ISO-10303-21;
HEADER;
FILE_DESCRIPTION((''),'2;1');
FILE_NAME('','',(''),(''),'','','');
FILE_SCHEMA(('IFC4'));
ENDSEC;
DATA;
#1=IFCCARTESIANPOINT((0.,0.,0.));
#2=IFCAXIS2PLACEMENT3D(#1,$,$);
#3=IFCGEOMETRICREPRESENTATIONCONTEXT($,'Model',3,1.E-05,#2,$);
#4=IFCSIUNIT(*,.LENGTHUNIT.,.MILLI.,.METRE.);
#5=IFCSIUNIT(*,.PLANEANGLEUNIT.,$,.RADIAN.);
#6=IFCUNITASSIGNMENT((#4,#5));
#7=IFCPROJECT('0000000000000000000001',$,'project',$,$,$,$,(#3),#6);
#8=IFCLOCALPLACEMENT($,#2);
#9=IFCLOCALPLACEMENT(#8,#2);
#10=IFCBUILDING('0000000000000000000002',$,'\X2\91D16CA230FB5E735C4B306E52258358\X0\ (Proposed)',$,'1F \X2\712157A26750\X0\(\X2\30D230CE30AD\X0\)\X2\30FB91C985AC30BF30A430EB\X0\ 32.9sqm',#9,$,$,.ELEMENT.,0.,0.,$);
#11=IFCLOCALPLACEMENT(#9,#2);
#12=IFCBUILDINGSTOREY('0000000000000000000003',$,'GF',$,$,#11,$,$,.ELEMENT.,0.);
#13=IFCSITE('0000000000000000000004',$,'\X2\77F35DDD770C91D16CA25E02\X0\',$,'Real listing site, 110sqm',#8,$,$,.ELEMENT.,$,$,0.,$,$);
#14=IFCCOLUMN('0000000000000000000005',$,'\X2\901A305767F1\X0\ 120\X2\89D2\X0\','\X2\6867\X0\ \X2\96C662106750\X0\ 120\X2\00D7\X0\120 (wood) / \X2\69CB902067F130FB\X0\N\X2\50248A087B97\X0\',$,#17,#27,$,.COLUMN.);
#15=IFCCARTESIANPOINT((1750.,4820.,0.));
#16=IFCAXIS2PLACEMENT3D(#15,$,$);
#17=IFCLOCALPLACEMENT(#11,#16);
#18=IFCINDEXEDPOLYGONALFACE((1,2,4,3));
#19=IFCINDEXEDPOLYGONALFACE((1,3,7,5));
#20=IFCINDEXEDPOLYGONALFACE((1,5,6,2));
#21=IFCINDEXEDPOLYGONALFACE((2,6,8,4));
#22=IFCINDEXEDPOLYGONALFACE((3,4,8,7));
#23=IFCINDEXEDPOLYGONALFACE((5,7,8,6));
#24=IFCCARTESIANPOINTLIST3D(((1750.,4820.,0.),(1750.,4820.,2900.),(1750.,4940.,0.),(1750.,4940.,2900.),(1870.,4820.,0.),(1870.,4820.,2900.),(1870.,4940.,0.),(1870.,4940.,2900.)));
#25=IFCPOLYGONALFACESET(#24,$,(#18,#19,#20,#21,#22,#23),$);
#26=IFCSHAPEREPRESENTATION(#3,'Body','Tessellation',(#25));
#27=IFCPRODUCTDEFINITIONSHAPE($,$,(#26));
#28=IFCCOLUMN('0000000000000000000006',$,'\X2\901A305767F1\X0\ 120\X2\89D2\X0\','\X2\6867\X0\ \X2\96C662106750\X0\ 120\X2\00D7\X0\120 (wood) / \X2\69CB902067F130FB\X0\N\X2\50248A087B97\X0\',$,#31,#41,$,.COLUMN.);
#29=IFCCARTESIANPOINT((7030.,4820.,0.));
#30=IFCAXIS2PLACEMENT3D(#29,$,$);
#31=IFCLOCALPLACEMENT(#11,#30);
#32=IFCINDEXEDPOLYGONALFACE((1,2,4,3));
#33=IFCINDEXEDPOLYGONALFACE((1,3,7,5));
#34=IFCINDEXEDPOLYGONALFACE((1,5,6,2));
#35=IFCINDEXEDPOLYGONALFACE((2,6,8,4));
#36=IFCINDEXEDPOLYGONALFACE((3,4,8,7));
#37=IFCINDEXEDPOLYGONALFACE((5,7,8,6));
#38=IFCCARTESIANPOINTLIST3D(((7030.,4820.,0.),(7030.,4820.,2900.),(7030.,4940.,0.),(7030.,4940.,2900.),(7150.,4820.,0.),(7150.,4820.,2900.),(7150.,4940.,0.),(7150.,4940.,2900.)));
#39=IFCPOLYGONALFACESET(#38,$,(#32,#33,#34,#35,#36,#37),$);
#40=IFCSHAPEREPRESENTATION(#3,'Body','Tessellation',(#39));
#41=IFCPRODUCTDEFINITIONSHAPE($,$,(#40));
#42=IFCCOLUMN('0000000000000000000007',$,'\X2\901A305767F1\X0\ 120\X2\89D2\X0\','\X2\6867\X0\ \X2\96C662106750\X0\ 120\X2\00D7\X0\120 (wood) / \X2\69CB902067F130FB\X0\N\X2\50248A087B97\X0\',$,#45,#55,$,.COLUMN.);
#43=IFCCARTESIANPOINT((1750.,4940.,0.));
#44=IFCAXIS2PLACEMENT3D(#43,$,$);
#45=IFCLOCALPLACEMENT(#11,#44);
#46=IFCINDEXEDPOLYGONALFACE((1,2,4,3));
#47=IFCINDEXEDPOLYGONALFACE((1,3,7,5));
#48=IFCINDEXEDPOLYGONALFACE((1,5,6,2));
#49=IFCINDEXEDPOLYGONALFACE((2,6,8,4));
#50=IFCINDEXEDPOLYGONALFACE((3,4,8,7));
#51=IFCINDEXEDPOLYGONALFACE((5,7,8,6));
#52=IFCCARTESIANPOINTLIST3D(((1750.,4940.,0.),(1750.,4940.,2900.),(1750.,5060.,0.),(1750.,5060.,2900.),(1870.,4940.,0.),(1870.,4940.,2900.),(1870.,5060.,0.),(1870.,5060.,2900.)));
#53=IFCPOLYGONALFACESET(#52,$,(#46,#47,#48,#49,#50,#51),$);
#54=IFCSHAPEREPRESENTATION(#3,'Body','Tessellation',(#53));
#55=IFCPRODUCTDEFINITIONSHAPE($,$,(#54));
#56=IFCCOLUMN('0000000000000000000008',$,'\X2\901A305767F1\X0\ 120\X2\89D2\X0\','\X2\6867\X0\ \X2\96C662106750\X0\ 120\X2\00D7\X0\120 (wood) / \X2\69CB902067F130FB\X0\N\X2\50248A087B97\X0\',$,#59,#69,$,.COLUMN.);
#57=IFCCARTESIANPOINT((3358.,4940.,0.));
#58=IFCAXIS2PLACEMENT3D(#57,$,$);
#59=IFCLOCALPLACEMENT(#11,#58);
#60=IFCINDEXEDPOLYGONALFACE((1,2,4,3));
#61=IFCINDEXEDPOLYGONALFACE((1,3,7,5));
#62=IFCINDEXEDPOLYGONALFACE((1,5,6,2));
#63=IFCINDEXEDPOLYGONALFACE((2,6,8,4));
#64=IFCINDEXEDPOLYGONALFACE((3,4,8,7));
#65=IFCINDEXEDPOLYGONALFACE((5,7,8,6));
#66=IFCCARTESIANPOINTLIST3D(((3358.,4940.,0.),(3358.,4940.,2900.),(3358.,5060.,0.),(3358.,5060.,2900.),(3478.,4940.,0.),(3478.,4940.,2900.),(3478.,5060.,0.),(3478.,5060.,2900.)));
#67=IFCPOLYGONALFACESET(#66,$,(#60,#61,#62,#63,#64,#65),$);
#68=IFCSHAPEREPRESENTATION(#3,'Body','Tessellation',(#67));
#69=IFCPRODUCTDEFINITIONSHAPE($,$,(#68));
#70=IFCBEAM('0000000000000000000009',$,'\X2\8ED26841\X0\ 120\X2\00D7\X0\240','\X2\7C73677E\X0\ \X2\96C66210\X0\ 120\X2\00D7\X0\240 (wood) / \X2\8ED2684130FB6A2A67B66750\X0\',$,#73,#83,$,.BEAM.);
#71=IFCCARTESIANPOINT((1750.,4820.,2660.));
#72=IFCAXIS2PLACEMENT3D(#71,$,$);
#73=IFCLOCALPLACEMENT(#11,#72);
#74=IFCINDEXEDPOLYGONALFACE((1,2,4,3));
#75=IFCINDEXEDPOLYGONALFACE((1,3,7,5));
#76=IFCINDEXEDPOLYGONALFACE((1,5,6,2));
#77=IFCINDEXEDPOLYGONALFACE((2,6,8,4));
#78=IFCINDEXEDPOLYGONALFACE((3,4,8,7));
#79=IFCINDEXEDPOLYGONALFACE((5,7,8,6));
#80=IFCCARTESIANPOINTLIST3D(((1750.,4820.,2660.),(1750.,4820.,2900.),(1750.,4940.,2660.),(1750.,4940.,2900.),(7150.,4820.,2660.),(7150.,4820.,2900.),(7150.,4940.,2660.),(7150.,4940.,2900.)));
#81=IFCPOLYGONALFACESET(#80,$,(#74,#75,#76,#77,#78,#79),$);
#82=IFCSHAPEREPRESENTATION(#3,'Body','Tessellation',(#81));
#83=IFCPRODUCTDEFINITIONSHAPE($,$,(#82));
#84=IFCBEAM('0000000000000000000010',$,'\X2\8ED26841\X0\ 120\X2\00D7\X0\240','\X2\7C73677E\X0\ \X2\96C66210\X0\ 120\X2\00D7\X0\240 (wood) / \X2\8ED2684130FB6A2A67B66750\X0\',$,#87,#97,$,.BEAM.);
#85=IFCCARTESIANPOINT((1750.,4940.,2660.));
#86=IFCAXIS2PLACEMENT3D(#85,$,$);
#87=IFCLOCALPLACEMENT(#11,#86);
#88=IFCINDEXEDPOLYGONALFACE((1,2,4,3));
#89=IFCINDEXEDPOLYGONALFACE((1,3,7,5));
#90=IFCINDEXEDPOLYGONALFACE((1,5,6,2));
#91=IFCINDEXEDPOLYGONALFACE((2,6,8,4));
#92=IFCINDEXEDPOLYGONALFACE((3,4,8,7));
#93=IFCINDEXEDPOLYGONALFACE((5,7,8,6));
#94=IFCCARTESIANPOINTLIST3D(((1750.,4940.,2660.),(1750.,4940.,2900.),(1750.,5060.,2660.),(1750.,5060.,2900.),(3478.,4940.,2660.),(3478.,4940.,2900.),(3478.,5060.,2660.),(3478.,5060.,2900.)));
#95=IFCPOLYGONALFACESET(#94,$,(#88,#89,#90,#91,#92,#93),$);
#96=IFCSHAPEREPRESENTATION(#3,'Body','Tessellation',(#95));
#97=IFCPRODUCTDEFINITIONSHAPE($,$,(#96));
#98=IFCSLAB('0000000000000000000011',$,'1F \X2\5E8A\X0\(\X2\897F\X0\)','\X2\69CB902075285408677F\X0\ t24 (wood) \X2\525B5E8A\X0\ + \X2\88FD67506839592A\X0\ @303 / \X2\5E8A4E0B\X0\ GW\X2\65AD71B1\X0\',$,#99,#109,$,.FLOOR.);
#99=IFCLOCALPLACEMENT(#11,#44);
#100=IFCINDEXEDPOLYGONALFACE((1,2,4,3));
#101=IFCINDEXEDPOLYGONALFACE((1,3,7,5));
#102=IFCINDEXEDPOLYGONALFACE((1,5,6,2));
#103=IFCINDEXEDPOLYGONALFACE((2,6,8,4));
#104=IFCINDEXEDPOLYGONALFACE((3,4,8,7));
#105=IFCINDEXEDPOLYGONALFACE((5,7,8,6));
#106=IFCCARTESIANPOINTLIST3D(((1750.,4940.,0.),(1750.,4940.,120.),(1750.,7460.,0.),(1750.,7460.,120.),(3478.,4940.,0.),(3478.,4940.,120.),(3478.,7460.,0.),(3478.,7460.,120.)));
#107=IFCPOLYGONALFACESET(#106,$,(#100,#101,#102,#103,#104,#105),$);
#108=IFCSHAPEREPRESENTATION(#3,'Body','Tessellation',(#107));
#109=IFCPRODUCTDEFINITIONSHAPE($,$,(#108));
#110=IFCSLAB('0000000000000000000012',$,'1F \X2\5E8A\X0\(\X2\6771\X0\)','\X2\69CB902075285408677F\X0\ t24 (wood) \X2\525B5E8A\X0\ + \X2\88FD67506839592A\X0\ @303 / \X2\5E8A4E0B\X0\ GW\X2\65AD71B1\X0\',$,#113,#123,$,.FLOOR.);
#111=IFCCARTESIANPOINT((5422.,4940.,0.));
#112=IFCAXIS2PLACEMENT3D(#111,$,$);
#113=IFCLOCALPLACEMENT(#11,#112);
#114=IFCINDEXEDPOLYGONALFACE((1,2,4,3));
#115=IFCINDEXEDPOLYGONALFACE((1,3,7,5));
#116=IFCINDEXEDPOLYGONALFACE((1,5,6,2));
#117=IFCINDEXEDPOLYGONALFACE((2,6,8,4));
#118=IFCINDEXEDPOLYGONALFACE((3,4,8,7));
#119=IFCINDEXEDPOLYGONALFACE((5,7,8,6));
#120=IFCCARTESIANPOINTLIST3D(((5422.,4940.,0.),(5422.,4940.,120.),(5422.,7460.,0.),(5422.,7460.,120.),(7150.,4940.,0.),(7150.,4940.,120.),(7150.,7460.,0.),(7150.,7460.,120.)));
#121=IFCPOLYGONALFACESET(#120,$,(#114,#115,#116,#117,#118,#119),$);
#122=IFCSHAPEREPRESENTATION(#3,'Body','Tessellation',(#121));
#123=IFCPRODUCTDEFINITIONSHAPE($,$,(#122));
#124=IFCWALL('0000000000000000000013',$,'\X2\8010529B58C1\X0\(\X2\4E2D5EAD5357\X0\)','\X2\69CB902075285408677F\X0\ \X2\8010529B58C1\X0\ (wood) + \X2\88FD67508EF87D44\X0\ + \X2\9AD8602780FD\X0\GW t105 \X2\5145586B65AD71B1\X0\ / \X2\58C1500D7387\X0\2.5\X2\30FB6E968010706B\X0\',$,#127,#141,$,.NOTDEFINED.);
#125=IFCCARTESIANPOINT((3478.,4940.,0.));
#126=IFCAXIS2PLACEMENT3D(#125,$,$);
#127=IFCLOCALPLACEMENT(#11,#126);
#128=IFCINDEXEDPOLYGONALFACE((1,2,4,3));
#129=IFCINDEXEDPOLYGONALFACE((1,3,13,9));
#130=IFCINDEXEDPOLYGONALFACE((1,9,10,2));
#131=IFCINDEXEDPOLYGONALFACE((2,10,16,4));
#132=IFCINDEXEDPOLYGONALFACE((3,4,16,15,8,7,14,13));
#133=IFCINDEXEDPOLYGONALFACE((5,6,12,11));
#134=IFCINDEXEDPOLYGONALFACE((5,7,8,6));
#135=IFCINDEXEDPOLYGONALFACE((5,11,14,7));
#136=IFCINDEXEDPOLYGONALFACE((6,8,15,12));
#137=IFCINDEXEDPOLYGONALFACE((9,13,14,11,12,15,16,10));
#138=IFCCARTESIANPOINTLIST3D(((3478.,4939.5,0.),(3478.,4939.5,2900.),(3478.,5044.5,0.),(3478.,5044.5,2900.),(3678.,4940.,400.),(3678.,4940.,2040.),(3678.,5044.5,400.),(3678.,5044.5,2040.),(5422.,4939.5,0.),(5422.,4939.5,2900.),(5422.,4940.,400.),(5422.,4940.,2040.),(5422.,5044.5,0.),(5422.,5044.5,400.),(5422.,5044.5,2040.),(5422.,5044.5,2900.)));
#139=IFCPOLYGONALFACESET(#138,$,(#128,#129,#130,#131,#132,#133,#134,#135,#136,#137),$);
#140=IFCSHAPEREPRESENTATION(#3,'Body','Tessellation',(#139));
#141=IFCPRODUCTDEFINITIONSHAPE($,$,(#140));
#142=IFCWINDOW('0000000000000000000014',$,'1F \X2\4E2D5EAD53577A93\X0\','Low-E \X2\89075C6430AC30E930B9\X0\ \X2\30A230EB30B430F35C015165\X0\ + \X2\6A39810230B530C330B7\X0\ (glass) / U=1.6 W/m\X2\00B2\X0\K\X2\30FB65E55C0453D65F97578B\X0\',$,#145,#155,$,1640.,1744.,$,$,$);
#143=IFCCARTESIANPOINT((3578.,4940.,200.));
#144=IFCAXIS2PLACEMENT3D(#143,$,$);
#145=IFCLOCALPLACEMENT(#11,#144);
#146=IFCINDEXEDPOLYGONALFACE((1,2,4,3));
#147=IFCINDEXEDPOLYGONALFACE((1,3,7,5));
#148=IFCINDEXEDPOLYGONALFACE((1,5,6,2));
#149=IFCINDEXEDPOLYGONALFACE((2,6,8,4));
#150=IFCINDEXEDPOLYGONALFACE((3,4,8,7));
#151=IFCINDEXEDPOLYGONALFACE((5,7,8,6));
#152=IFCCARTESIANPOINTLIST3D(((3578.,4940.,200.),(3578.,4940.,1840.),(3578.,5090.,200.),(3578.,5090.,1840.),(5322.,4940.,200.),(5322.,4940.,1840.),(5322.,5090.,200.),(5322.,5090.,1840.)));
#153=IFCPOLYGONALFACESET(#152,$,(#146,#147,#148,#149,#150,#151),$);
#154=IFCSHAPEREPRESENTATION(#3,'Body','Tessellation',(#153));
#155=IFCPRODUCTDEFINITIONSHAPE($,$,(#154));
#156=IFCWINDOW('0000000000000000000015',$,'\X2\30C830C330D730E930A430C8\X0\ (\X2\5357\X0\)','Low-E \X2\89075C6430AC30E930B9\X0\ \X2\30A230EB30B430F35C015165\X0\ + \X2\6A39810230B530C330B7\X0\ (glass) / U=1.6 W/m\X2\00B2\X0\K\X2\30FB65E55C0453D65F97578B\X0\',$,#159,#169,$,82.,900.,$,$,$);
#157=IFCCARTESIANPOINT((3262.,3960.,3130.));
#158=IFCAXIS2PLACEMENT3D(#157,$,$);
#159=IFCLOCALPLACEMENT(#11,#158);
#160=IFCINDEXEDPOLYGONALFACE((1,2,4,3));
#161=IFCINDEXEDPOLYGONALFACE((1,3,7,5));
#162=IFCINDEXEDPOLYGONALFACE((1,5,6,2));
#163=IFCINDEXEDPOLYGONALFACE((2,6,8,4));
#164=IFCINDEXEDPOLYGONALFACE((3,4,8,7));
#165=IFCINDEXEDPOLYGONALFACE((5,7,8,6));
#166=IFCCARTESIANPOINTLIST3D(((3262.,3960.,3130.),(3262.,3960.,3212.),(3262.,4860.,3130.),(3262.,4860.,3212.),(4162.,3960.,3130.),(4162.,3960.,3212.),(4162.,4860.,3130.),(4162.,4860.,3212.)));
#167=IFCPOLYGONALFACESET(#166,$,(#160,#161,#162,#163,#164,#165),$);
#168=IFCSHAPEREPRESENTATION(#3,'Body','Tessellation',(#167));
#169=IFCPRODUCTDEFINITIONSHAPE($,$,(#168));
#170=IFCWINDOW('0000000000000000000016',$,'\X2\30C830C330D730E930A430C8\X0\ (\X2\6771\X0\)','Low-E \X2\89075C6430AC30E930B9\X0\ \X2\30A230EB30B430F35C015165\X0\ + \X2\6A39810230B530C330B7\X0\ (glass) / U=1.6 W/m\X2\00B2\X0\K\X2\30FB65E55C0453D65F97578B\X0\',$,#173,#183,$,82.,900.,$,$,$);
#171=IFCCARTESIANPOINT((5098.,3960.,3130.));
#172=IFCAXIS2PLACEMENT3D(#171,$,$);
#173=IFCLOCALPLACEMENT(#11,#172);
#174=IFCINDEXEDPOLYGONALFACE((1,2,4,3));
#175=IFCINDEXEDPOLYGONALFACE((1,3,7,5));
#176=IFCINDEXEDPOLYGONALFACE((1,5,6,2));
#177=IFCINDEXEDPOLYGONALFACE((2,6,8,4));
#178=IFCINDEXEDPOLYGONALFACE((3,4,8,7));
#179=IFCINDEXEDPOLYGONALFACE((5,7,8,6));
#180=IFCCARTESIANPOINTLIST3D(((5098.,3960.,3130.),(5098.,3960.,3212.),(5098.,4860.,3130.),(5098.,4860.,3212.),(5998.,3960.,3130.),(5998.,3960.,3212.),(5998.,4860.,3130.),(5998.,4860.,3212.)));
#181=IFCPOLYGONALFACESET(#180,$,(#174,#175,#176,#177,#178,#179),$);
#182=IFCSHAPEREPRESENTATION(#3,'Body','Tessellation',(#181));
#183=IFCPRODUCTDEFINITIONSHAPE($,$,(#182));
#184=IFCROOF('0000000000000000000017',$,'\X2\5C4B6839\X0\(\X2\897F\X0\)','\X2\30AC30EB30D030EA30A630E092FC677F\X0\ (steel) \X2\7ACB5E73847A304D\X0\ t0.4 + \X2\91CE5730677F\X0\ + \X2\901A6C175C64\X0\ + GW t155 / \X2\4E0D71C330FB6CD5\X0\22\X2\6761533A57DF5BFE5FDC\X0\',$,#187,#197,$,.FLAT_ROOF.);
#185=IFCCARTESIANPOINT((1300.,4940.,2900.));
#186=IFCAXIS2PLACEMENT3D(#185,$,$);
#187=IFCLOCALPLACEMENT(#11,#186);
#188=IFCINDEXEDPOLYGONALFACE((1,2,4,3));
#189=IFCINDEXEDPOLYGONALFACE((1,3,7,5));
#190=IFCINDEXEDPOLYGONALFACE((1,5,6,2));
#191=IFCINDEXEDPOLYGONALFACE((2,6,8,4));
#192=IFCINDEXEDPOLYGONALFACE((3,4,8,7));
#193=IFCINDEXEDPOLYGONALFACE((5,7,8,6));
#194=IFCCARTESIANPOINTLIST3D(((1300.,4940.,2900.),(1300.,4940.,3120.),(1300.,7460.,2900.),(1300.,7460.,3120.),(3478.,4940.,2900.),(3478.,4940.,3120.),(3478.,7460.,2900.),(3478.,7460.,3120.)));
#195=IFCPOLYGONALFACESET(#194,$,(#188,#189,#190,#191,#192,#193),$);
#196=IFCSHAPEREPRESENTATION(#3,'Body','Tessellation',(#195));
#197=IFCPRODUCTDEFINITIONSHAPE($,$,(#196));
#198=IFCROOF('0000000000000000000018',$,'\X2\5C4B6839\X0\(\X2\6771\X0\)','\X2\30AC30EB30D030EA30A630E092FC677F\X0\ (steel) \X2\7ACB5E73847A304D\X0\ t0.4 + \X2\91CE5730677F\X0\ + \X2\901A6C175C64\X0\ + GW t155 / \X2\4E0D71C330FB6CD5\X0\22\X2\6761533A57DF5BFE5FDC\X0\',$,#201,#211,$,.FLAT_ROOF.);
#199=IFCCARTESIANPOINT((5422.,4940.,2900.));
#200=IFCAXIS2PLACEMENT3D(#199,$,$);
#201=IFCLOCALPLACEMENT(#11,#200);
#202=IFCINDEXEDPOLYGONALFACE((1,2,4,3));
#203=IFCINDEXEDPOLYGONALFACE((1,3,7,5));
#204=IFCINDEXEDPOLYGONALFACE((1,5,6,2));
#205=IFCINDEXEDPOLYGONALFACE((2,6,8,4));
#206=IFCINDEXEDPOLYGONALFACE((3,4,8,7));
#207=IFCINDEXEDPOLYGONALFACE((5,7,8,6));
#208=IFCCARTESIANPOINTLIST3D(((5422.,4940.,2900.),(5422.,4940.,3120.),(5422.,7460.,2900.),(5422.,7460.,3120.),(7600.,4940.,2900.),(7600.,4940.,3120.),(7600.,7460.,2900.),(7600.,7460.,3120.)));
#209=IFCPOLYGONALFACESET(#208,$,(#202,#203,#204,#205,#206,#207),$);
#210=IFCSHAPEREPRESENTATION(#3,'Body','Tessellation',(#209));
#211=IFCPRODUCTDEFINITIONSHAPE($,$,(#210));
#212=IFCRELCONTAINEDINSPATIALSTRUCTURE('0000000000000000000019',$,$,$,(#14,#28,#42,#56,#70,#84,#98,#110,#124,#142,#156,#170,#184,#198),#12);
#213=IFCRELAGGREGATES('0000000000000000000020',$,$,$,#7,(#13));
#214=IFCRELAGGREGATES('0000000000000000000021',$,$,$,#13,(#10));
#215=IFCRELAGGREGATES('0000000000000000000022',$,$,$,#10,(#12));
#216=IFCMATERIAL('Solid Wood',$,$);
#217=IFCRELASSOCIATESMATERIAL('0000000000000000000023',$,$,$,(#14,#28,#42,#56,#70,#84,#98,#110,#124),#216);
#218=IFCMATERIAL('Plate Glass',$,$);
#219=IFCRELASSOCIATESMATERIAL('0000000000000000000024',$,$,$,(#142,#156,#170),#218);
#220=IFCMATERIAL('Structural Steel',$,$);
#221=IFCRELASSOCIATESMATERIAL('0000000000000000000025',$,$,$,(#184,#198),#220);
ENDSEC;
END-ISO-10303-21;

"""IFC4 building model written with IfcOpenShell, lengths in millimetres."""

from ifc_helpers import new_model, si_unit, frame, frame_2d, origin, place, context, project, spatial, rectangle, extrude, material, element, fill, save


model = new_model("IFC4")

# Units and contexts
model_context = context("Model", 3, precision=1e-05, world=origin())
ifc_project = project(units=[si_unit("LENGTHUNIT", "METRE", prefix="MILLI"), si_unit("PLANEANGLEUNIT", "RADIAN")], contexts=[model_context])

# Site, building, storey
site_placement = place(None, origin())
site = spatial("IfcSite", under=ifc_project, at=site_placement, Name="石川県金沢市", ObjectType="Real listing site, 110sqm", CompositionType="ELEMENT", RefElevation=0.0)
building_placement = place(site_placement, origin())
building = spatial("IfcBuilding", under=site, at=building_placement, Name="金沢・平屋の別荘 (Proposed)", ObjectType="1F 無垢材(ヒノキ)・釉薬タイル 32.9sqm", CompositionType="ELEMENT", ElevationOfRefHeight=0.0, ElevationOfTerrain=0.0)
storey_placement = place(building_placement, origin())
storey = spatial("IfcBuildingStorey", under=building, at=storey_placement, Name="GF", CompositionType="ELEMENT", Elevation=0.0)

# Columns
ifc_material_1 = material(Name="Solid Wood")
column_1_placement = place(storey_placement, frame((1750.0, 4820.0, 0.0)))
element("IfcColumn", 1, at=column_1_placement, inside=storey, material=ifc_material_1, Name="通し柱 120角", Description="桧 集成材 120×120 (wood) / 構造柱・N値計算", PredefinedType="COLUMN", context=model_context, shape_type="SweptSolid", body=[
    extrude(rectangle(XDim=120.0, YDim=120.0, at=frame_2d((60.0, 60.0))), frame((1750.0, 4820.0, 0.0)), (0.0, 0.0, 1.0), 2900.0),
])
column_2_placement = place(storey_placement, frame((7030.0, 4820.0, 0.0)))
element("IfcColumn", 2, at=column_2_placement, inside=storey, material=ifc_material_1, Name="通し柱 120角", Description="桧 集成材 120×120 (wood) / 構造柱・N値計算", PredefinedType="COLUMN", context=model_context, shape_type="SweptSolid", body=[
    extrude(rectangle(XDim=120.0, YDim=120.0, at=frame_2d((60.0, 60.0))), frame((7030.0, 4820.0, 0.0)), (0.0, 0.0, 1.0), 2900.0),
])
column_3_placement = place(storey_placement, frame((1750.0, 4940.0, 0.0)))
element("IfcColumn", 3, at=column_3_placement, inside=storey, material=ifc_material_1, Name="通し柱 120角", Description="桧 集成材 120×120 (wood) / 構造柱・N値計算", PredefinedType="COLUMN", context=model_context, shape_type="SweptSolid", body=[
    extrude(rectangle(XDim=120.0, YDim=120.0, at=frame_2d((60.0, 60.0))), frame((1750.0, 4940.0, 0.0)), (0.0, 0.0, 1.0), 2900.0),
])
column_4_placement = place(storey_placement, frame((3358.0, 4940.0, 0.0)))
element("IfcColumn", 4, at=column_4_placement, inside=storey, material=ifc_material_1, Name="通し柱 120角", Description="桧 集成材 120×120 (wood) / 構造柱・N値計算", PredefinedType="COLUMN", context=model_context, shape_type="SweptSolid", body=[
    extrude(rectangle(XDim=120.0, YDim=120.0, at=frame_2d((60.0, 60.0))), frame((3358.0, 4940.0, 0.0)), (0.0, 0.0, 1.0), 2900.0),
])

# Beams
beam_1_placement = place(storey_placement, frame((1750.0, 4820.0, 2660.0)))
element("IfcBeam", 5, at=beam_1_placement, inside=storey, material=ifc_material_1, Name="軒桁 120×240", Description="米松 集成 120×240 (wood) / 軒桁・横架材", PredefinedType="BEAM", context=model_context, shape_type="SweptSolid", body=[
    extrude(rectangle(XDim=5400.0, YDim=120.0, at=frame_2d((2700.0, 60.0))), frame((1750.0, 4820.0, 2660.0)), (0.0, 0.0, 1.0), 240.0),
])
beam_2_placement = place(storey_placement, frame((1750.0, 4940.0, 2660.0)))
element("IfcBeam", 6, at=beam_2_placement, inside=storey, material=ifc_material_1, Name="軒桁 120×240", Description="米松 集成 120×240 (wood) / 軒桁・横架材", PredefinedType="BEAM", context=model_context, shape_type="SweptSolid", body=[
    extrude(rectangle(XDim=1728.0, YDim=120.0, at=frame_2d((864.0, 60.0))), frame((1750.0, 4940.0, 2660.0)), (0.0, 0.0, 1.0), 240.0),
])

# Slabs
slab_1_placement = place(storey_placement, frame((1750.0, 4940.0, 0.0)))
element("IfcSlab", 7, at=slab_1_placement, inside=storey, material=ifc_material_1, Name="1F 床(西)", Description="構造用合板 t24 (wood) 剛床 + 製材根太 @303 / 床下 GW断熱", PredefinedType="FLOOR", context=model_context, shape_type="SweptSolid", body=[
    extrude(rectangle(XDim=1728.0, YDim=2520.0, at=frame_2d((864.0, 1260.0))), frame((1750.0, 4940.0, 0.0)), (0.0, 0.0, 1.0), 120.0),
])
slab_2_placement = place(storey_placement, frame((5422.0, 4940.0, 0.0)))
element("IfcSlab", 8, at=slab_2_placement, inside=storey, material=ifc_material_1, Name="1F 床(東)", Description="構造用合板 t24 (wood) 剛床 + 製材根太 @303 / 床下 GW断熱", PredefinedType="FLOOR", context=model_context, shape_type="SweptSolid", body=[
    extrude(rectangle(XDim=1728.0, YDim=2520.0, at=frame_2d((864.0, 1260.0))), frame((5422.0, 4940.0, 0.0)), (0.0, 0.0, 1.0), 120.0),
])

# Wall, opening, window
wall_1_placement = place(storey_placement, frame((3478.0, 4940.0, 0.0)))
wall_1 = element("IfcWall", 9, at=wall_1_placement, inside=storey, material=ifc_material_1, Name="耐力壁(中庭南)", Description="構造用合板 耐力壁 (wood) + 製材軸組 + 高性能GW t105 充填断熱 / 壁倍率2.5・準耐火", PredefinedType="NOTDEFINED", context=model_context, shape_type="SweptSolid", body=[
    extrude(rectangle(XDim=1944.0, YDim=105.0, at=frame_2d((972.0, 52.0))), frame((3478.0, 4940.0, 0.0)), (0.0, 0.0, 1.0), 2900.0),
])
opening_placement = place(storey_placement, frame((3578.0, 4940.0, 200.0)))
opening = element("IfcOpeningElement", 10, at=opening_placement, cuts=wall_1, PredefinedType="NOTDEFINED", context=model_context, shape_type="SweptSolid", body=[
    extrude(rectangle(XDim=1744.0, YDim=150.0, at=frame_2d((872.0, 75.0))), frame((3578.0, 4940.0, 200.0)), (0.0, 0.0, 1.0), 1640.0),
])
ifc_material_2 = material(Name="Plate Glass")
window_1_placement = place(storey_placement, frame((3578.0, 4940.0, 200.0)))
window_1 = element("IfcWindow", 11, at=window_1_placement, inside=storey, material=ifc_material_2, Name="1F 中庭南窓", Description="Low-E 複層ガラス アルゴン封入 + 樹脂サッシ (glass) / U=1.6 W/m²K・日射取得型", OverallHeight=1640.0, OverallWidth=1744.0, context=model_context, shape_type="SweptSolid", body=[
    extrude(rectangle(XDim=1744.0, YDim=150.0, at=frame_2d((872.0, 75.0))), frame((3578.0, 4940.0, 200.0)), (0.0, 0.0, 1.0), 1640.0),
])
fill(opening, window_1)

# Windows
window_2_placement = place(storey_placement, frame((3262.0, 3960.0, 3130.0)))
element("IfcWindow", 12, at=window_2_placement, inside=storey, material=ifc_material_2, Name="トップライト (南)", Description="Low-E 複層ガラス アルゴン封入 + 樹脂サッシ (glass) / U=1.6 W/m²K・日射取得型", OverallHeight=82.0, OverallWidth=900.0, context=model_context, shape_type="SweptSolid", body=[
    extrude(rectangle(XDim=900.0, YDim=900.0, at=frame_2d((450.0, 450.0))), frame((3262.0, 3960.0, 3130.0)), (0.0, 0.0, 1.0), 82.0),
])
window_3_placement = place(storey_placement, frame((5098.0, 3960.0, 3130.0)))
element("IfcWindow", 13, at=window_3_placement, inside=storey, material=ifc_material_2, Name="トップライト (東)", Description="Low-E 複層ガラス アルゴン封入 + 樹脂サッシ (glass) / U=1.6 W/m²K・日射取得型", OverallHeight=82.0, OverallWidth=900.0, context=model_context, shape_type="SweptSolid", body=[
    extrude(rectangle(XDim=900.0, YDim=900.0, at=frame_2d((450.0, 450.0))), frame((5098.0, 3960.0, 3130.0)), (0.0, 0.0, 1.0), 82.0),
])

# Roofs
ifc_material_3 = material(Name="Structural Steel")
roof_1_placement = place(storey_placement, frame((1300.0, 4940.0, 2900.0)))
element("IfcRoof", 14, at=roof_1_placement, inside=storey, material=ifc_material_3, Name="屋根(西)", Description="ガルバリウム鋼板 (steel) 立平葺き t0.4 + 野地板 + 通気層 + GW t155 / 不燃・法22条区域対応", PredefinedType="FLAT_ROOF", context=model_context, shape_type="SweptSolid", body=[
    extrude(rectangle(XDim=2178.0, YDim=2520.0, at=frame_2d((1089.0, 1260.0))), frame((1300.0, 4940.0, 2900.0)), (0.0, 0.0, 1.0), 220.0),
])
roof_2_placement = place(storey_placement, frame((5422.0, 4940.0, 2900.0)))
element("IfcRoof", 15, at=roof_2_placement, inside=storey, material=ifc_material_3, Name="屋根(東)", Description="ガルバリウム鋼板 (steel) 立平葺き t0.4 + 野地板 + 通気層 + GW t155 / 不燃・法22条区域対応", PredefinedType="FLAT_ROOF", context=model_context, shape_type="SweptSolid", body=[
    extrude(rectangle(XDim=2178.0, YDim=2520.0, at=frame_2d((1089.0, 1260.0))), frame((5422.0, 4940.0, 2900.0)), (0.0, 0.0, 1.0), 220.0),
])

save(model, "model.ifc")
